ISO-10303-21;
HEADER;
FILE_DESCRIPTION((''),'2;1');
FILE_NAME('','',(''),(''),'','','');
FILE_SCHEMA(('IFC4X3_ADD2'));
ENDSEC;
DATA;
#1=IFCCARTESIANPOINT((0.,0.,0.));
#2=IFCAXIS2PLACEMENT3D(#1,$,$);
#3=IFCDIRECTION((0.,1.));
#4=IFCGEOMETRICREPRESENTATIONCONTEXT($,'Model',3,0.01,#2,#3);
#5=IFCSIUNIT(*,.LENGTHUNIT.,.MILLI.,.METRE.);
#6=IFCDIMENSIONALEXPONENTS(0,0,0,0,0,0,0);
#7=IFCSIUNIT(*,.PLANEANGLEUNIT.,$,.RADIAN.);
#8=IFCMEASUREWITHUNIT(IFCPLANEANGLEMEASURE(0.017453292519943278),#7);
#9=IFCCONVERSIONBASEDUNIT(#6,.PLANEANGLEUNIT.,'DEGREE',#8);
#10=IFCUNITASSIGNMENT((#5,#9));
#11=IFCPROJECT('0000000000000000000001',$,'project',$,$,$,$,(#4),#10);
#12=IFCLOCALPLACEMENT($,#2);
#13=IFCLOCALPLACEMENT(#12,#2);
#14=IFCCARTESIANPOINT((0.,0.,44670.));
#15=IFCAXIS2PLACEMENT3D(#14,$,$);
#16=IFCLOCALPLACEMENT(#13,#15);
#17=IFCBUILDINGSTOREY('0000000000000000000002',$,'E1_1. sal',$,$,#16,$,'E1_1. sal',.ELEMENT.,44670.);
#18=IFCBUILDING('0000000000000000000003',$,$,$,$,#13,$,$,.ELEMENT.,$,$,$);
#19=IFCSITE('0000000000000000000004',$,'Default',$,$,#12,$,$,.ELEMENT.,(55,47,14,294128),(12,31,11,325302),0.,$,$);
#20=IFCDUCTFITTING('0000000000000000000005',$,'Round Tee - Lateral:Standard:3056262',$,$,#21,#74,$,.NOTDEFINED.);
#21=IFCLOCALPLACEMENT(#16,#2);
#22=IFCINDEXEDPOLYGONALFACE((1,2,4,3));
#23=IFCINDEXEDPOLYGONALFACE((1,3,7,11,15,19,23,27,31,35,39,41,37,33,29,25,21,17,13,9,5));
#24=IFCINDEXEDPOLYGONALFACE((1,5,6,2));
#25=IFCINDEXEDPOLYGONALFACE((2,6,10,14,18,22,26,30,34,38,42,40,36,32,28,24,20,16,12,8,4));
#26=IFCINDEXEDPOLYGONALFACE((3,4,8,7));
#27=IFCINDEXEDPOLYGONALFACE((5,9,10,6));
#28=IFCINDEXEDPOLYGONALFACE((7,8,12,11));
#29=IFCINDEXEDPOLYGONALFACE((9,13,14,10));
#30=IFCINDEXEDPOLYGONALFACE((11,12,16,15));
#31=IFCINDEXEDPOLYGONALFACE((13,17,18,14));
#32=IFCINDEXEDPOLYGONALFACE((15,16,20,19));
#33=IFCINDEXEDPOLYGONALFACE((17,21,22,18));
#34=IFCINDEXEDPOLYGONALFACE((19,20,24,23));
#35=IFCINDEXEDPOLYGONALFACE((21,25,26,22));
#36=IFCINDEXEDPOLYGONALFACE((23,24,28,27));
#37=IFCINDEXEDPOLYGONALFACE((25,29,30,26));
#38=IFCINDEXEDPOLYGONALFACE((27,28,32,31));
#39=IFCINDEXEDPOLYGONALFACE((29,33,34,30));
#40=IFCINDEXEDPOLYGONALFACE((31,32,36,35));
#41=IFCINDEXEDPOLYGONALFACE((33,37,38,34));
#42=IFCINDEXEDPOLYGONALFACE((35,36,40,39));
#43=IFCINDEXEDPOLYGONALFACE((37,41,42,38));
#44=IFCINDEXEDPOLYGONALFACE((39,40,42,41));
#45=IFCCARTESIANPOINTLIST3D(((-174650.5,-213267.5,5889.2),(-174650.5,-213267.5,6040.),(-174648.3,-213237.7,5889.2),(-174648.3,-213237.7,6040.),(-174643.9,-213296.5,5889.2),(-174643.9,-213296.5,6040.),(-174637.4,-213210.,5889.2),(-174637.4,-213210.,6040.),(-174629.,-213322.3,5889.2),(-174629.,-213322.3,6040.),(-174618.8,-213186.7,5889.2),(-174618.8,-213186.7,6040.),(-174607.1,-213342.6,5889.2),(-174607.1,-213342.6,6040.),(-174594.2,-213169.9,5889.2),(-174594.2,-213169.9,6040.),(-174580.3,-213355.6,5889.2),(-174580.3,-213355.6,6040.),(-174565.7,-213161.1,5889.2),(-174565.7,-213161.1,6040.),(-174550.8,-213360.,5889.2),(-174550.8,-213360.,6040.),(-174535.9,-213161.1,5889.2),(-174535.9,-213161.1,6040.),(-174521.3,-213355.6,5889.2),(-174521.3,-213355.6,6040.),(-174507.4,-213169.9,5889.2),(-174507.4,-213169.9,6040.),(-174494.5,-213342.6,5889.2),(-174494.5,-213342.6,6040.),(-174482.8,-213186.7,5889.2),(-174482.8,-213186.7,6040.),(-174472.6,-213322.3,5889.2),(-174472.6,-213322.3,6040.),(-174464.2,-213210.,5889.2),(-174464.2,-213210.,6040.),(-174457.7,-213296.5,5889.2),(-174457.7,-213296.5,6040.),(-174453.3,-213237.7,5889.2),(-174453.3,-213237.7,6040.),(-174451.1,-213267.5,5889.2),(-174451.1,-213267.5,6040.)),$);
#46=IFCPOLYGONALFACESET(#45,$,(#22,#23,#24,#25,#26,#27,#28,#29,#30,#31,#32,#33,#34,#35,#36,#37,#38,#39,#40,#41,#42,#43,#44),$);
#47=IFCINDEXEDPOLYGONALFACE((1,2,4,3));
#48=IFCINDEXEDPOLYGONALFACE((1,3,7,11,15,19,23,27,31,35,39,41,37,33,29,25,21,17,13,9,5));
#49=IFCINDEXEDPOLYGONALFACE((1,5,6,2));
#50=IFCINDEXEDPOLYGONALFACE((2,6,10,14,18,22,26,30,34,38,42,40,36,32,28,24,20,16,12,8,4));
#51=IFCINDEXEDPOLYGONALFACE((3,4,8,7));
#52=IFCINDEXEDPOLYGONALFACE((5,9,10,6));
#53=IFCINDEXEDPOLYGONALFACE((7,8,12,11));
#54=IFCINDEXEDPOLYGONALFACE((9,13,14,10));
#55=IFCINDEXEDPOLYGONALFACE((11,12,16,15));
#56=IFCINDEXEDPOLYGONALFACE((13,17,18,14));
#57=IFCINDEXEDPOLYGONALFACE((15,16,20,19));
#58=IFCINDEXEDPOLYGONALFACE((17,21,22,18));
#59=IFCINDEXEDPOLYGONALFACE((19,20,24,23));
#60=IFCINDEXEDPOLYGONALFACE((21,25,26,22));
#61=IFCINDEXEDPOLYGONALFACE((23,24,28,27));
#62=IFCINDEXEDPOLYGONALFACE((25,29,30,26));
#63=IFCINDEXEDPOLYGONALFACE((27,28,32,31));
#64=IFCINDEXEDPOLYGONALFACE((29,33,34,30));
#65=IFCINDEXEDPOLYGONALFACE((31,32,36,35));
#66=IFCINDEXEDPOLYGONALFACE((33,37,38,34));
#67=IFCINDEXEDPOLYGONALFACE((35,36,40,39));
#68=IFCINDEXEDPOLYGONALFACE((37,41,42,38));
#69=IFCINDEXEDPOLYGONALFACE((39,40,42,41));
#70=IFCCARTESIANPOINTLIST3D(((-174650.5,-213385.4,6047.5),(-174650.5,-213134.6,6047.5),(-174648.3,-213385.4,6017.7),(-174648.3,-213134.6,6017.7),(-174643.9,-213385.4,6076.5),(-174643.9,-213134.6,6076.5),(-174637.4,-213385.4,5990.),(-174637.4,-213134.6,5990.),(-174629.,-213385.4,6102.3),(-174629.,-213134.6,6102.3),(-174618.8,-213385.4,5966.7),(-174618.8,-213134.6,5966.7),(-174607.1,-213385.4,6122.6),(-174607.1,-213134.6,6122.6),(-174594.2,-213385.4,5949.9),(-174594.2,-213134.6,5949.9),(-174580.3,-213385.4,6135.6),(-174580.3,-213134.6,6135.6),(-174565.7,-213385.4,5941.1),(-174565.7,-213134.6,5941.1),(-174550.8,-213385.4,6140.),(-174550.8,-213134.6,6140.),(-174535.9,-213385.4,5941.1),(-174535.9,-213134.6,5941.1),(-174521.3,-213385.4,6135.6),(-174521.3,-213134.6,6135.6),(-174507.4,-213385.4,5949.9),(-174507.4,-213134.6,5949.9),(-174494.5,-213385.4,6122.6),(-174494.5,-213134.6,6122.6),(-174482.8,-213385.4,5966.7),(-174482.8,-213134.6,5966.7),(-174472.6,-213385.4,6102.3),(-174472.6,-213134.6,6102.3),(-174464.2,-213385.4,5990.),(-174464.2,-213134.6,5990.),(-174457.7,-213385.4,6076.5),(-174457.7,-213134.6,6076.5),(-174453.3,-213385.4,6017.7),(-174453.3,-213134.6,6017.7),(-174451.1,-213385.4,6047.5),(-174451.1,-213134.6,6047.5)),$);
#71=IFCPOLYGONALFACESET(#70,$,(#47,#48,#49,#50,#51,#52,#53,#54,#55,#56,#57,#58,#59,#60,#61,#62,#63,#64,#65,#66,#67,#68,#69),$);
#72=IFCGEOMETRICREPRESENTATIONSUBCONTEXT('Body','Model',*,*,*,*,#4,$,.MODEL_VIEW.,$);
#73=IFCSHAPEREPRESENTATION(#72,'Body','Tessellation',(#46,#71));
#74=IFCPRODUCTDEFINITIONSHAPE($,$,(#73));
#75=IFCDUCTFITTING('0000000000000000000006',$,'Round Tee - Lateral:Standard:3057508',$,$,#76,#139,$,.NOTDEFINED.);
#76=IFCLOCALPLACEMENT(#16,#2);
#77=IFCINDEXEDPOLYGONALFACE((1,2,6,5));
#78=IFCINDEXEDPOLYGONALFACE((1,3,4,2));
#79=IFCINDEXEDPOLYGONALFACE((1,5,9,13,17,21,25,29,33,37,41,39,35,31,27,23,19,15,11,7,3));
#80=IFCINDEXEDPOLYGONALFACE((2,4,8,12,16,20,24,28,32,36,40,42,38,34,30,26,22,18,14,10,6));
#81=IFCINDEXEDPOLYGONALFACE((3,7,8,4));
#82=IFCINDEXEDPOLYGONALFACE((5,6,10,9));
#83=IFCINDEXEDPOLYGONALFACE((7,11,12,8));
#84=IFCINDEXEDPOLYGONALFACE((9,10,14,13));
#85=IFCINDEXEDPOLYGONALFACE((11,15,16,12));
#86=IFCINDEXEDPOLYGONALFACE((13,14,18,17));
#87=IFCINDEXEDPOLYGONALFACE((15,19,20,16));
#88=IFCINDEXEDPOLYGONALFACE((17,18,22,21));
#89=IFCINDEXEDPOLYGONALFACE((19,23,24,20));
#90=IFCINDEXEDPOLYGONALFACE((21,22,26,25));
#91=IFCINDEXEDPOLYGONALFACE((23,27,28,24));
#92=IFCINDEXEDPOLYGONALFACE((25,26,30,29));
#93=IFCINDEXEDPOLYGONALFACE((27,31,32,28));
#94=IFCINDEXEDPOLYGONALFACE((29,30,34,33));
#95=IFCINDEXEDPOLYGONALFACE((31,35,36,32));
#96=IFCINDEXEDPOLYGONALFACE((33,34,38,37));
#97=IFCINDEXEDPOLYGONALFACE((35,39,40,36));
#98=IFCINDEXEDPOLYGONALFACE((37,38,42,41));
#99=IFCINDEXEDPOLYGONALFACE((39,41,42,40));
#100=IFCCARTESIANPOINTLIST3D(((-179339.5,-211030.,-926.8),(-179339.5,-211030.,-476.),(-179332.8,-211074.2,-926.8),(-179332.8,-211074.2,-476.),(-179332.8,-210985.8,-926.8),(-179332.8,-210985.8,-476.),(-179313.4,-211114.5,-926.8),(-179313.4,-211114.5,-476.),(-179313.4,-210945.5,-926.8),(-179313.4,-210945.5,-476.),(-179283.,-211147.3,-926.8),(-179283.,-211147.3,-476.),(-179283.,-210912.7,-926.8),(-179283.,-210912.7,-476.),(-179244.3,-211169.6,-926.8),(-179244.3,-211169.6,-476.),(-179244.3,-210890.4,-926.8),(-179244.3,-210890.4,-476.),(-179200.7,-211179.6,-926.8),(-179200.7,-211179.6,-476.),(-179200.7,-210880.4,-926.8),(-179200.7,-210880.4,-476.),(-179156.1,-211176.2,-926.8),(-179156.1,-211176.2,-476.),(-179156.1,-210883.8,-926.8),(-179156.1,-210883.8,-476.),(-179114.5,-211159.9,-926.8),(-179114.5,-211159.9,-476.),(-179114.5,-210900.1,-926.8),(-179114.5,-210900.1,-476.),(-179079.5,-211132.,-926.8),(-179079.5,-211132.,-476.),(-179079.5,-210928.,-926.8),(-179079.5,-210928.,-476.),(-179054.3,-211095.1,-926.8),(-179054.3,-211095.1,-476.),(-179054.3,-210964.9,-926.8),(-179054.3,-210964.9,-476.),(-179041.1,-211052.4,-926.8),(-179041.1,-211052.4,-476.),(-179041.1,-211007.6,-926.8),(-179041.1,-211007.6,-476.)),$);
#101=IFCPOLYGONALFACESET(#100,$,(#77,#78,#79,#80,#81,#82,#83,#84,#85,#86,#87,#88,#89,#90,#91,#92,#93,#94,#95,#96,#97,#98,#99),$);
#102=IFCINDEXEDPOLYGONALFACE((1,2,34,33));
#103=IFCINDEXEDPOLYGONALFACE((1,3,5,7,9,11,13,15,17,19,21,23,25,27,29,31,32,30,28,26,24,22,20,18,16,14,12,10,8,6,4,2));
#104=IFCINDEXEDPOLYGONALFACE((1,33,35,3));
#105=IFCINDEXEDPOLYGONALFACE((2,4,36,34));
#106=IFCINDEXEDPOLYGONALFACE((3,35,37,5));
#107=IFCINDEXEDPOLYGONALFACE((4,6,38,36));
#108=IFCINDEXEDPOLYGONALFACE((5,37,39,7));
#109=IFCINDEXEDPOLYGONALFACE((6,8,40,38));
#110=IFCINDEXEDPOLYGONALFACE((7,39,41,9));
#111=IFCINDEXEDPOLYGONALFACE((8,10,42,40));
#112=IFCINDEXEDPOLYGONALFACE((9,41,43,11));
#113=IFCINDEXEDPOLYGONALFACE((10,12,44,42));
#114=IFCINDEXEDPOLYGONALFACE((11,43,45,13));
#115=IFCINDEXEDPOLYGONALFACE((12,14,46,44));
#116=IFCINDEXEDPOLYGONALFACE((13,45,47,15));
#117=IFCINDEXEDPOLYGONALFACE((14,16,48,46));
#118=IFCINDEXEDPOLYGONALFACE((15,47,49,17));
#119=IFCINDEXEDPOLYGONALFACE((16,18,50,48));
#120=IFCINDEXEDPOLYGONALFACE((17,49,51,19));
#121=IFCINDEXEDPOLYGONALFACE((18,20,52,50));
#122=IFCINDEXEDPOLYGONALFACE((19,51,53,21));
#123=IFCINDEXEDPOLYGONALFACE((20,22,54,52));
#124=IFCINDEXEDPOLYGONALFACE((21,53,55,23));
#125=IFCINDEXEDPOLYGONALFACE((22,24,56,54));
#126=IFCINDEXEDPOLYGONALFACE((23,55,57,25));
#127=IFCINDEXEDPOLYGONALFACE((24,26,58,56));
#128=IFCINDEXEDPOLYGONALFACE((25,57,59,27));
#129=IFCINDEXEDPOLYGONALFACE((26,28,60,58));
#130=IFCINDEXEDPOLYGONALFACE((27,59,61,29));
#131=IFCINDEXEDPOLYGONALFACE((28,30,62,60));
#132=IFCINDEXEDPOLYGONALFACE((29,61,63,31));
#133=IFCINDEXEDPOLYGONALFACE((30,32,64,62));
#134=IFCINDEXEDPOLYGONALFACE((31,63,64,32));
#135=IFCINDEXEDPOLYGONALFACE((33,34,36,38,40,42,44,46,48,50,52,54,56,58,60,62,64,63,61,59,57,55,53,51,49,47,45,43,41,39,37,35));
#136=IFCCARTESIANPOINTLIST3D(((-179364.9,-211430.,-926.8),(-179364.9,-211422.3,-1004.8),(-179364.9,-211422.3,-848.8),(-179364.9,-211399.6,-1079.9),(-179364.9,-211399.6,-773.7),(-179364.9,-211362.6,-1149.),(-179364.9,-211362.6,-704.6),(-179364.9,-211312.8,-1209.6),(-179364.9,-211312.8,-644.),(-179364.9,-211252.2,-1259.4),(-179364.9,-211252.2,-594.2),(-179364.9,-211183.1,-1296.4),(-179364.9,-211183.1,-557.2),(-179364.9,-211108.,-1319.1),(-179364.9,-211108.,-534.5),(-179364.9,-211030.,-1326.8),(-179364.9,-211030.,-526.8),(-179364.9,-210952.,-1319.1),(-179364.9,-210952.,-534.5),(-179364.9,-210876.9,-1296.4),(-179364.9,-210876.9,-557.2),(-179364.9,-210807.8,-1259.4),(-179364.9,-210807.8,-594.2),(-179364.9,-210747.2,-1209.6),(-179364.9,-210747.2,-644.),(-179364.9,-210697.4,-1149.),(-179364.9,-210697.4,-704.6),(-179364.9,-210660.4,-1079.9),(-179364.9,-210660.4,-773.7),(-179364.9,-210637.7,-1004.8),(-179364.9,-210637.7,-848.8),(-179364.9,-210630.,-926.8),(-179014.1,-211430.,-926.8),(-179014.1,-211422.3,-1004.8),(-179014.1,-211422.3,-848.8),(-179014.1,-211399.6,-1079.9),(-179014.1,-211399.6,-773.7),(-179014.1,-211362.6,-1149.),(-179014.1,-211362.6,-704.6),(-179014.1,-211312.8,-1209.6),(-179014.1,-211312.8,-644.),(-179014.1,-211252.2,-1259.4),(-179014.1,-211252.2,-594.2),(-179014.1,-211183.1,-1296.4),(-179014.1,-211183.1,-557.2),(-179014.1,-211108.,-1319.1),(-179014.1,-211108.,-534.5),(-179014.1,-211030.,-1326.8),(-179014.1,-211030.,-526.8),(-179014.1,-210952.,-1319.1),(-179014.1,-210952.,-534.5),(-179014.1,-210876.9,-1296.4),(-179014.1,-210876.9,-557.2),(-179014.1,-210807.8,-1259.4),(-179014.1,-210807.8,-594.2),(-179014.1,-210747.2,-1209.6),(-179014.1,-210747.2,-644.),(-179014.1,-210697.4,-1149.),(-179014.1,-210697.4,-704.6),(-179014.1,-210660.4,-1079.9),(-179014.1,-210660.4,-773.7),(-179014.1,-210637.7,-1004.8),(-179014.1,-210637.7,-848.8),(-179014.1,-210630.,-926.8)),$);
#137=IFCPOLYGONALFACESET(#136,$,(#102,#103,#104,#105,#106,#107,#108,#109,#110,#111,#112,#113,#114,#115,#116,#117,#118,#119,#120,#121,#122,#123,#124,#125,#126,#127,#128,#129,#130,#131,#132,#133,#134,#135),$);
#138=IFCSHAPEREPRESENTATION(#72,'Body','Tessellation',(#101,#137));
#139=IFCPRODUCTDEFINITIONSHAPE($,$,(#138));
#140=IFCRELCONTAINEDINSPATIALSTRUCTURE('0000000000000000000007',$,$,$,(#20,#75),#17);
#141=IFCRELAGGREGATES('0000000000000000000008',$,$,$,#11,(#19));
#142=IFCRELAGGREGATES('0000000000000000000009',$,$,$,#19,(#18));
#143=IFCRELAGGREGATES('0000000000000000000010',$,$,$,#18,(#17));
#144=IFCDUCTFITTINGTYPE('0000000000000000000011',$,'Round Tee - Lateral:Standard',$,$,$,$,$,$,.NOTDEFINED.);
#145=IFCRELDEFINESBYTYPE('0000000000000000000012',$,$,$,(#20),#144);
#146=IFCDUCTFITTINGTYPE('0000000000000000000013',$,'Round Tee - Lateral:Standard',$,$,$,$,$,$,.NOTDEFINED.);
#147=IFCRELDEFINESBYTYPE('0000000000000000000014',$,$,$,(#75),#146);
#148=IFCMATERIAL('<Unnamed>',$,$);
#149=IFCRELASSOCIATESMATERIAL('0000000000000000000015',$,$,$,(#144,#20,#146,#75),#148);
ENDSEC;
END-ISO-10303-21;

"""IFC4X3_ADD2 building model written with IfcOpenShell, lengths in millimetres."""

from ifc_helpers import new_model, entity, si_unit, converted_unit, direction, frame, frame_2d, origin, place, context, subcontext, project, spatial, circle, extrude, source, transform, mapped, material, type_object, type_shapes, element, save


model = new_model("IFC4X3_ADD2")

# Units and contexts
model_context = context("Model", 3, precision=0.01, world=origin(), true_north=direction((0.0, 1.0)))
body_context = subcontext(model_context, "Body", "Model", "MODEL_VIEW")
ifc_project = project(units=[si_unit("LENGTHUNIT", "METRE", prefix="MILLI"), converted_unit("PLANEANGLEUNIT", "DEGREE", entity("IfcPlaneAngleMeasure", 0.017453292519943278), si_unit("PLANEANGLEUNIT", "RADIAN"), dimensions=[0, 0, 0, 0, 0, 0, 0])], contexts=[model_context])

# Site, building, storey
site_placement = place(None, origin())
site = spatial("IfcSite", under=ifc_project, at=site_placement, Name="Default", CompositionType="ELEMENT", RefLatitude=(55, 47, 14, 294128), RefLongitude=(12, 31, 11, 325302), RefElevation=0.0)
building_placement = place(site_placement, origin())
building = spatial("IfcBuilding", under=site, at=building_placement, CompositionType="ELEMENT")
storey_placement = place(building_placement, frame((0.0, 0.0, 44670.0)))
storey = spatial("IfcBuildingStorey", under=building, at=storey_placement, Name="E1_1. sal", LongName="E1_1. sal", CompositionType="ELEMENT", Elevation=44670.0)

# Shared definitions
ifc_material_1 = material(Name="<Unnamed>")

# Duct fittings
duct_fitting_type_1 = type_object("IfcDuctFittingType", Name="Round Tee - Lateral:Standard", PredefinedType="NOTDEFINED", material=ifc_material_1)
shared_shape_1 = source(origin(), body_context, "Body", "SweptSolid", [
    extrude(circle(Radius=100.0, at=frame_2d((0.0, 0.0), x_axis=(1.0, 0.0))), frame((0.0, -150.8, 0.0), z_axis=(0.0, 1.0, 0.0), x_axis=(1.0, 0.0, 0.0)), (0.0, 0.0, 1.0), 150.8),
    extrude(circle(Radius=100.0, at=frame_2d((0.0, 0.0), x_axis=(1.0, 0.0))), frame((-125.4, 0.0, 0.0), z_axis=(1.0, 0.0, 0.0), x_axis=(0.0, 1.0, 0.0)), (0.0, 0.0, 1.0), 250.8),
])
type_shapes(duct_fitting_type_1, [shared_shape_1])
duct_fitting_1_placement = place(storey_placement, frame((-174550.8, -213260.0, 6040.0), z_axis=(-1.0, 0.0, 0.0), x_axis=(0.0, -1.0, 0.0)))
element("IfcDuctFitting", 1, at=duct_fitting_1_placement, inside=storey, type_object=duct_fitting_type_1, material=ifc_material_1, Name="Round Tee - Lateral:Standard:3056262", PredefinedType="NOTDEFINED", context=body_context, shape_type="MappedRepresentation", body=[
    mapped(shared_shape_1, transform((0.0, 0.0, 0.0), scale=1.0)),
])
duct_fitting_type_2 = type_object("IfcDuctFittingType", Name="Round Tee - Lateral:Standard", PredefinedType="NOTDEFINED", material=ifc_material_1)
shared_shape_2 = source(origin(), body_context, "Body", "SweptSolid", [
    extrude(circle(Radius=150.0, at=frame_2d((0.0, 0.0), x_axis=(1.0, 0.0))), frame((0.0, -450.8, 0.0), z_axis=(0.0, 1.0, 0.0), x_axis=(1.0, 0.0, 0.0)), (0.0, 0.0, 1.0), 450.8),
    extrude(circle(Radius=400.0, at=frame_2d((0.0, 0.0), x_axis=(1.0, 0.0))), frame((-175.4, 0.0, 0.0), z_axis=(1.0, 0.0, 0.0), x_axis=(0.0, 1.0, 0.0)), (0.0, 0.0, 1.0), 350.8),
])
type_shapes(duct_fitting_type_2, [shared_shape_2])
duct_fitting_2_placement = place(storey_placement, frame((-179189.5, -211030.0, -926.8), z_axis=(0.0, -1.0, 0.0), x_axis=(-1.0, 0.0, 0.0)))
element("IfcDuctFitting", 2, at=duct_fitting_2_placement, inside=storey, type_object=duct_fitting_type_2, material=ifc_material_1, Name="Round Tee - Lateral:Standard:3057508", PredefinedType="NOTDEFINED", context=body_context, shape_type="MappedRepresentation", body=[
    mapped(shared_shape_2, transform((0.0, 0.0, 0.0), scale=1.0)),
])

save(model, "model.ifc")
